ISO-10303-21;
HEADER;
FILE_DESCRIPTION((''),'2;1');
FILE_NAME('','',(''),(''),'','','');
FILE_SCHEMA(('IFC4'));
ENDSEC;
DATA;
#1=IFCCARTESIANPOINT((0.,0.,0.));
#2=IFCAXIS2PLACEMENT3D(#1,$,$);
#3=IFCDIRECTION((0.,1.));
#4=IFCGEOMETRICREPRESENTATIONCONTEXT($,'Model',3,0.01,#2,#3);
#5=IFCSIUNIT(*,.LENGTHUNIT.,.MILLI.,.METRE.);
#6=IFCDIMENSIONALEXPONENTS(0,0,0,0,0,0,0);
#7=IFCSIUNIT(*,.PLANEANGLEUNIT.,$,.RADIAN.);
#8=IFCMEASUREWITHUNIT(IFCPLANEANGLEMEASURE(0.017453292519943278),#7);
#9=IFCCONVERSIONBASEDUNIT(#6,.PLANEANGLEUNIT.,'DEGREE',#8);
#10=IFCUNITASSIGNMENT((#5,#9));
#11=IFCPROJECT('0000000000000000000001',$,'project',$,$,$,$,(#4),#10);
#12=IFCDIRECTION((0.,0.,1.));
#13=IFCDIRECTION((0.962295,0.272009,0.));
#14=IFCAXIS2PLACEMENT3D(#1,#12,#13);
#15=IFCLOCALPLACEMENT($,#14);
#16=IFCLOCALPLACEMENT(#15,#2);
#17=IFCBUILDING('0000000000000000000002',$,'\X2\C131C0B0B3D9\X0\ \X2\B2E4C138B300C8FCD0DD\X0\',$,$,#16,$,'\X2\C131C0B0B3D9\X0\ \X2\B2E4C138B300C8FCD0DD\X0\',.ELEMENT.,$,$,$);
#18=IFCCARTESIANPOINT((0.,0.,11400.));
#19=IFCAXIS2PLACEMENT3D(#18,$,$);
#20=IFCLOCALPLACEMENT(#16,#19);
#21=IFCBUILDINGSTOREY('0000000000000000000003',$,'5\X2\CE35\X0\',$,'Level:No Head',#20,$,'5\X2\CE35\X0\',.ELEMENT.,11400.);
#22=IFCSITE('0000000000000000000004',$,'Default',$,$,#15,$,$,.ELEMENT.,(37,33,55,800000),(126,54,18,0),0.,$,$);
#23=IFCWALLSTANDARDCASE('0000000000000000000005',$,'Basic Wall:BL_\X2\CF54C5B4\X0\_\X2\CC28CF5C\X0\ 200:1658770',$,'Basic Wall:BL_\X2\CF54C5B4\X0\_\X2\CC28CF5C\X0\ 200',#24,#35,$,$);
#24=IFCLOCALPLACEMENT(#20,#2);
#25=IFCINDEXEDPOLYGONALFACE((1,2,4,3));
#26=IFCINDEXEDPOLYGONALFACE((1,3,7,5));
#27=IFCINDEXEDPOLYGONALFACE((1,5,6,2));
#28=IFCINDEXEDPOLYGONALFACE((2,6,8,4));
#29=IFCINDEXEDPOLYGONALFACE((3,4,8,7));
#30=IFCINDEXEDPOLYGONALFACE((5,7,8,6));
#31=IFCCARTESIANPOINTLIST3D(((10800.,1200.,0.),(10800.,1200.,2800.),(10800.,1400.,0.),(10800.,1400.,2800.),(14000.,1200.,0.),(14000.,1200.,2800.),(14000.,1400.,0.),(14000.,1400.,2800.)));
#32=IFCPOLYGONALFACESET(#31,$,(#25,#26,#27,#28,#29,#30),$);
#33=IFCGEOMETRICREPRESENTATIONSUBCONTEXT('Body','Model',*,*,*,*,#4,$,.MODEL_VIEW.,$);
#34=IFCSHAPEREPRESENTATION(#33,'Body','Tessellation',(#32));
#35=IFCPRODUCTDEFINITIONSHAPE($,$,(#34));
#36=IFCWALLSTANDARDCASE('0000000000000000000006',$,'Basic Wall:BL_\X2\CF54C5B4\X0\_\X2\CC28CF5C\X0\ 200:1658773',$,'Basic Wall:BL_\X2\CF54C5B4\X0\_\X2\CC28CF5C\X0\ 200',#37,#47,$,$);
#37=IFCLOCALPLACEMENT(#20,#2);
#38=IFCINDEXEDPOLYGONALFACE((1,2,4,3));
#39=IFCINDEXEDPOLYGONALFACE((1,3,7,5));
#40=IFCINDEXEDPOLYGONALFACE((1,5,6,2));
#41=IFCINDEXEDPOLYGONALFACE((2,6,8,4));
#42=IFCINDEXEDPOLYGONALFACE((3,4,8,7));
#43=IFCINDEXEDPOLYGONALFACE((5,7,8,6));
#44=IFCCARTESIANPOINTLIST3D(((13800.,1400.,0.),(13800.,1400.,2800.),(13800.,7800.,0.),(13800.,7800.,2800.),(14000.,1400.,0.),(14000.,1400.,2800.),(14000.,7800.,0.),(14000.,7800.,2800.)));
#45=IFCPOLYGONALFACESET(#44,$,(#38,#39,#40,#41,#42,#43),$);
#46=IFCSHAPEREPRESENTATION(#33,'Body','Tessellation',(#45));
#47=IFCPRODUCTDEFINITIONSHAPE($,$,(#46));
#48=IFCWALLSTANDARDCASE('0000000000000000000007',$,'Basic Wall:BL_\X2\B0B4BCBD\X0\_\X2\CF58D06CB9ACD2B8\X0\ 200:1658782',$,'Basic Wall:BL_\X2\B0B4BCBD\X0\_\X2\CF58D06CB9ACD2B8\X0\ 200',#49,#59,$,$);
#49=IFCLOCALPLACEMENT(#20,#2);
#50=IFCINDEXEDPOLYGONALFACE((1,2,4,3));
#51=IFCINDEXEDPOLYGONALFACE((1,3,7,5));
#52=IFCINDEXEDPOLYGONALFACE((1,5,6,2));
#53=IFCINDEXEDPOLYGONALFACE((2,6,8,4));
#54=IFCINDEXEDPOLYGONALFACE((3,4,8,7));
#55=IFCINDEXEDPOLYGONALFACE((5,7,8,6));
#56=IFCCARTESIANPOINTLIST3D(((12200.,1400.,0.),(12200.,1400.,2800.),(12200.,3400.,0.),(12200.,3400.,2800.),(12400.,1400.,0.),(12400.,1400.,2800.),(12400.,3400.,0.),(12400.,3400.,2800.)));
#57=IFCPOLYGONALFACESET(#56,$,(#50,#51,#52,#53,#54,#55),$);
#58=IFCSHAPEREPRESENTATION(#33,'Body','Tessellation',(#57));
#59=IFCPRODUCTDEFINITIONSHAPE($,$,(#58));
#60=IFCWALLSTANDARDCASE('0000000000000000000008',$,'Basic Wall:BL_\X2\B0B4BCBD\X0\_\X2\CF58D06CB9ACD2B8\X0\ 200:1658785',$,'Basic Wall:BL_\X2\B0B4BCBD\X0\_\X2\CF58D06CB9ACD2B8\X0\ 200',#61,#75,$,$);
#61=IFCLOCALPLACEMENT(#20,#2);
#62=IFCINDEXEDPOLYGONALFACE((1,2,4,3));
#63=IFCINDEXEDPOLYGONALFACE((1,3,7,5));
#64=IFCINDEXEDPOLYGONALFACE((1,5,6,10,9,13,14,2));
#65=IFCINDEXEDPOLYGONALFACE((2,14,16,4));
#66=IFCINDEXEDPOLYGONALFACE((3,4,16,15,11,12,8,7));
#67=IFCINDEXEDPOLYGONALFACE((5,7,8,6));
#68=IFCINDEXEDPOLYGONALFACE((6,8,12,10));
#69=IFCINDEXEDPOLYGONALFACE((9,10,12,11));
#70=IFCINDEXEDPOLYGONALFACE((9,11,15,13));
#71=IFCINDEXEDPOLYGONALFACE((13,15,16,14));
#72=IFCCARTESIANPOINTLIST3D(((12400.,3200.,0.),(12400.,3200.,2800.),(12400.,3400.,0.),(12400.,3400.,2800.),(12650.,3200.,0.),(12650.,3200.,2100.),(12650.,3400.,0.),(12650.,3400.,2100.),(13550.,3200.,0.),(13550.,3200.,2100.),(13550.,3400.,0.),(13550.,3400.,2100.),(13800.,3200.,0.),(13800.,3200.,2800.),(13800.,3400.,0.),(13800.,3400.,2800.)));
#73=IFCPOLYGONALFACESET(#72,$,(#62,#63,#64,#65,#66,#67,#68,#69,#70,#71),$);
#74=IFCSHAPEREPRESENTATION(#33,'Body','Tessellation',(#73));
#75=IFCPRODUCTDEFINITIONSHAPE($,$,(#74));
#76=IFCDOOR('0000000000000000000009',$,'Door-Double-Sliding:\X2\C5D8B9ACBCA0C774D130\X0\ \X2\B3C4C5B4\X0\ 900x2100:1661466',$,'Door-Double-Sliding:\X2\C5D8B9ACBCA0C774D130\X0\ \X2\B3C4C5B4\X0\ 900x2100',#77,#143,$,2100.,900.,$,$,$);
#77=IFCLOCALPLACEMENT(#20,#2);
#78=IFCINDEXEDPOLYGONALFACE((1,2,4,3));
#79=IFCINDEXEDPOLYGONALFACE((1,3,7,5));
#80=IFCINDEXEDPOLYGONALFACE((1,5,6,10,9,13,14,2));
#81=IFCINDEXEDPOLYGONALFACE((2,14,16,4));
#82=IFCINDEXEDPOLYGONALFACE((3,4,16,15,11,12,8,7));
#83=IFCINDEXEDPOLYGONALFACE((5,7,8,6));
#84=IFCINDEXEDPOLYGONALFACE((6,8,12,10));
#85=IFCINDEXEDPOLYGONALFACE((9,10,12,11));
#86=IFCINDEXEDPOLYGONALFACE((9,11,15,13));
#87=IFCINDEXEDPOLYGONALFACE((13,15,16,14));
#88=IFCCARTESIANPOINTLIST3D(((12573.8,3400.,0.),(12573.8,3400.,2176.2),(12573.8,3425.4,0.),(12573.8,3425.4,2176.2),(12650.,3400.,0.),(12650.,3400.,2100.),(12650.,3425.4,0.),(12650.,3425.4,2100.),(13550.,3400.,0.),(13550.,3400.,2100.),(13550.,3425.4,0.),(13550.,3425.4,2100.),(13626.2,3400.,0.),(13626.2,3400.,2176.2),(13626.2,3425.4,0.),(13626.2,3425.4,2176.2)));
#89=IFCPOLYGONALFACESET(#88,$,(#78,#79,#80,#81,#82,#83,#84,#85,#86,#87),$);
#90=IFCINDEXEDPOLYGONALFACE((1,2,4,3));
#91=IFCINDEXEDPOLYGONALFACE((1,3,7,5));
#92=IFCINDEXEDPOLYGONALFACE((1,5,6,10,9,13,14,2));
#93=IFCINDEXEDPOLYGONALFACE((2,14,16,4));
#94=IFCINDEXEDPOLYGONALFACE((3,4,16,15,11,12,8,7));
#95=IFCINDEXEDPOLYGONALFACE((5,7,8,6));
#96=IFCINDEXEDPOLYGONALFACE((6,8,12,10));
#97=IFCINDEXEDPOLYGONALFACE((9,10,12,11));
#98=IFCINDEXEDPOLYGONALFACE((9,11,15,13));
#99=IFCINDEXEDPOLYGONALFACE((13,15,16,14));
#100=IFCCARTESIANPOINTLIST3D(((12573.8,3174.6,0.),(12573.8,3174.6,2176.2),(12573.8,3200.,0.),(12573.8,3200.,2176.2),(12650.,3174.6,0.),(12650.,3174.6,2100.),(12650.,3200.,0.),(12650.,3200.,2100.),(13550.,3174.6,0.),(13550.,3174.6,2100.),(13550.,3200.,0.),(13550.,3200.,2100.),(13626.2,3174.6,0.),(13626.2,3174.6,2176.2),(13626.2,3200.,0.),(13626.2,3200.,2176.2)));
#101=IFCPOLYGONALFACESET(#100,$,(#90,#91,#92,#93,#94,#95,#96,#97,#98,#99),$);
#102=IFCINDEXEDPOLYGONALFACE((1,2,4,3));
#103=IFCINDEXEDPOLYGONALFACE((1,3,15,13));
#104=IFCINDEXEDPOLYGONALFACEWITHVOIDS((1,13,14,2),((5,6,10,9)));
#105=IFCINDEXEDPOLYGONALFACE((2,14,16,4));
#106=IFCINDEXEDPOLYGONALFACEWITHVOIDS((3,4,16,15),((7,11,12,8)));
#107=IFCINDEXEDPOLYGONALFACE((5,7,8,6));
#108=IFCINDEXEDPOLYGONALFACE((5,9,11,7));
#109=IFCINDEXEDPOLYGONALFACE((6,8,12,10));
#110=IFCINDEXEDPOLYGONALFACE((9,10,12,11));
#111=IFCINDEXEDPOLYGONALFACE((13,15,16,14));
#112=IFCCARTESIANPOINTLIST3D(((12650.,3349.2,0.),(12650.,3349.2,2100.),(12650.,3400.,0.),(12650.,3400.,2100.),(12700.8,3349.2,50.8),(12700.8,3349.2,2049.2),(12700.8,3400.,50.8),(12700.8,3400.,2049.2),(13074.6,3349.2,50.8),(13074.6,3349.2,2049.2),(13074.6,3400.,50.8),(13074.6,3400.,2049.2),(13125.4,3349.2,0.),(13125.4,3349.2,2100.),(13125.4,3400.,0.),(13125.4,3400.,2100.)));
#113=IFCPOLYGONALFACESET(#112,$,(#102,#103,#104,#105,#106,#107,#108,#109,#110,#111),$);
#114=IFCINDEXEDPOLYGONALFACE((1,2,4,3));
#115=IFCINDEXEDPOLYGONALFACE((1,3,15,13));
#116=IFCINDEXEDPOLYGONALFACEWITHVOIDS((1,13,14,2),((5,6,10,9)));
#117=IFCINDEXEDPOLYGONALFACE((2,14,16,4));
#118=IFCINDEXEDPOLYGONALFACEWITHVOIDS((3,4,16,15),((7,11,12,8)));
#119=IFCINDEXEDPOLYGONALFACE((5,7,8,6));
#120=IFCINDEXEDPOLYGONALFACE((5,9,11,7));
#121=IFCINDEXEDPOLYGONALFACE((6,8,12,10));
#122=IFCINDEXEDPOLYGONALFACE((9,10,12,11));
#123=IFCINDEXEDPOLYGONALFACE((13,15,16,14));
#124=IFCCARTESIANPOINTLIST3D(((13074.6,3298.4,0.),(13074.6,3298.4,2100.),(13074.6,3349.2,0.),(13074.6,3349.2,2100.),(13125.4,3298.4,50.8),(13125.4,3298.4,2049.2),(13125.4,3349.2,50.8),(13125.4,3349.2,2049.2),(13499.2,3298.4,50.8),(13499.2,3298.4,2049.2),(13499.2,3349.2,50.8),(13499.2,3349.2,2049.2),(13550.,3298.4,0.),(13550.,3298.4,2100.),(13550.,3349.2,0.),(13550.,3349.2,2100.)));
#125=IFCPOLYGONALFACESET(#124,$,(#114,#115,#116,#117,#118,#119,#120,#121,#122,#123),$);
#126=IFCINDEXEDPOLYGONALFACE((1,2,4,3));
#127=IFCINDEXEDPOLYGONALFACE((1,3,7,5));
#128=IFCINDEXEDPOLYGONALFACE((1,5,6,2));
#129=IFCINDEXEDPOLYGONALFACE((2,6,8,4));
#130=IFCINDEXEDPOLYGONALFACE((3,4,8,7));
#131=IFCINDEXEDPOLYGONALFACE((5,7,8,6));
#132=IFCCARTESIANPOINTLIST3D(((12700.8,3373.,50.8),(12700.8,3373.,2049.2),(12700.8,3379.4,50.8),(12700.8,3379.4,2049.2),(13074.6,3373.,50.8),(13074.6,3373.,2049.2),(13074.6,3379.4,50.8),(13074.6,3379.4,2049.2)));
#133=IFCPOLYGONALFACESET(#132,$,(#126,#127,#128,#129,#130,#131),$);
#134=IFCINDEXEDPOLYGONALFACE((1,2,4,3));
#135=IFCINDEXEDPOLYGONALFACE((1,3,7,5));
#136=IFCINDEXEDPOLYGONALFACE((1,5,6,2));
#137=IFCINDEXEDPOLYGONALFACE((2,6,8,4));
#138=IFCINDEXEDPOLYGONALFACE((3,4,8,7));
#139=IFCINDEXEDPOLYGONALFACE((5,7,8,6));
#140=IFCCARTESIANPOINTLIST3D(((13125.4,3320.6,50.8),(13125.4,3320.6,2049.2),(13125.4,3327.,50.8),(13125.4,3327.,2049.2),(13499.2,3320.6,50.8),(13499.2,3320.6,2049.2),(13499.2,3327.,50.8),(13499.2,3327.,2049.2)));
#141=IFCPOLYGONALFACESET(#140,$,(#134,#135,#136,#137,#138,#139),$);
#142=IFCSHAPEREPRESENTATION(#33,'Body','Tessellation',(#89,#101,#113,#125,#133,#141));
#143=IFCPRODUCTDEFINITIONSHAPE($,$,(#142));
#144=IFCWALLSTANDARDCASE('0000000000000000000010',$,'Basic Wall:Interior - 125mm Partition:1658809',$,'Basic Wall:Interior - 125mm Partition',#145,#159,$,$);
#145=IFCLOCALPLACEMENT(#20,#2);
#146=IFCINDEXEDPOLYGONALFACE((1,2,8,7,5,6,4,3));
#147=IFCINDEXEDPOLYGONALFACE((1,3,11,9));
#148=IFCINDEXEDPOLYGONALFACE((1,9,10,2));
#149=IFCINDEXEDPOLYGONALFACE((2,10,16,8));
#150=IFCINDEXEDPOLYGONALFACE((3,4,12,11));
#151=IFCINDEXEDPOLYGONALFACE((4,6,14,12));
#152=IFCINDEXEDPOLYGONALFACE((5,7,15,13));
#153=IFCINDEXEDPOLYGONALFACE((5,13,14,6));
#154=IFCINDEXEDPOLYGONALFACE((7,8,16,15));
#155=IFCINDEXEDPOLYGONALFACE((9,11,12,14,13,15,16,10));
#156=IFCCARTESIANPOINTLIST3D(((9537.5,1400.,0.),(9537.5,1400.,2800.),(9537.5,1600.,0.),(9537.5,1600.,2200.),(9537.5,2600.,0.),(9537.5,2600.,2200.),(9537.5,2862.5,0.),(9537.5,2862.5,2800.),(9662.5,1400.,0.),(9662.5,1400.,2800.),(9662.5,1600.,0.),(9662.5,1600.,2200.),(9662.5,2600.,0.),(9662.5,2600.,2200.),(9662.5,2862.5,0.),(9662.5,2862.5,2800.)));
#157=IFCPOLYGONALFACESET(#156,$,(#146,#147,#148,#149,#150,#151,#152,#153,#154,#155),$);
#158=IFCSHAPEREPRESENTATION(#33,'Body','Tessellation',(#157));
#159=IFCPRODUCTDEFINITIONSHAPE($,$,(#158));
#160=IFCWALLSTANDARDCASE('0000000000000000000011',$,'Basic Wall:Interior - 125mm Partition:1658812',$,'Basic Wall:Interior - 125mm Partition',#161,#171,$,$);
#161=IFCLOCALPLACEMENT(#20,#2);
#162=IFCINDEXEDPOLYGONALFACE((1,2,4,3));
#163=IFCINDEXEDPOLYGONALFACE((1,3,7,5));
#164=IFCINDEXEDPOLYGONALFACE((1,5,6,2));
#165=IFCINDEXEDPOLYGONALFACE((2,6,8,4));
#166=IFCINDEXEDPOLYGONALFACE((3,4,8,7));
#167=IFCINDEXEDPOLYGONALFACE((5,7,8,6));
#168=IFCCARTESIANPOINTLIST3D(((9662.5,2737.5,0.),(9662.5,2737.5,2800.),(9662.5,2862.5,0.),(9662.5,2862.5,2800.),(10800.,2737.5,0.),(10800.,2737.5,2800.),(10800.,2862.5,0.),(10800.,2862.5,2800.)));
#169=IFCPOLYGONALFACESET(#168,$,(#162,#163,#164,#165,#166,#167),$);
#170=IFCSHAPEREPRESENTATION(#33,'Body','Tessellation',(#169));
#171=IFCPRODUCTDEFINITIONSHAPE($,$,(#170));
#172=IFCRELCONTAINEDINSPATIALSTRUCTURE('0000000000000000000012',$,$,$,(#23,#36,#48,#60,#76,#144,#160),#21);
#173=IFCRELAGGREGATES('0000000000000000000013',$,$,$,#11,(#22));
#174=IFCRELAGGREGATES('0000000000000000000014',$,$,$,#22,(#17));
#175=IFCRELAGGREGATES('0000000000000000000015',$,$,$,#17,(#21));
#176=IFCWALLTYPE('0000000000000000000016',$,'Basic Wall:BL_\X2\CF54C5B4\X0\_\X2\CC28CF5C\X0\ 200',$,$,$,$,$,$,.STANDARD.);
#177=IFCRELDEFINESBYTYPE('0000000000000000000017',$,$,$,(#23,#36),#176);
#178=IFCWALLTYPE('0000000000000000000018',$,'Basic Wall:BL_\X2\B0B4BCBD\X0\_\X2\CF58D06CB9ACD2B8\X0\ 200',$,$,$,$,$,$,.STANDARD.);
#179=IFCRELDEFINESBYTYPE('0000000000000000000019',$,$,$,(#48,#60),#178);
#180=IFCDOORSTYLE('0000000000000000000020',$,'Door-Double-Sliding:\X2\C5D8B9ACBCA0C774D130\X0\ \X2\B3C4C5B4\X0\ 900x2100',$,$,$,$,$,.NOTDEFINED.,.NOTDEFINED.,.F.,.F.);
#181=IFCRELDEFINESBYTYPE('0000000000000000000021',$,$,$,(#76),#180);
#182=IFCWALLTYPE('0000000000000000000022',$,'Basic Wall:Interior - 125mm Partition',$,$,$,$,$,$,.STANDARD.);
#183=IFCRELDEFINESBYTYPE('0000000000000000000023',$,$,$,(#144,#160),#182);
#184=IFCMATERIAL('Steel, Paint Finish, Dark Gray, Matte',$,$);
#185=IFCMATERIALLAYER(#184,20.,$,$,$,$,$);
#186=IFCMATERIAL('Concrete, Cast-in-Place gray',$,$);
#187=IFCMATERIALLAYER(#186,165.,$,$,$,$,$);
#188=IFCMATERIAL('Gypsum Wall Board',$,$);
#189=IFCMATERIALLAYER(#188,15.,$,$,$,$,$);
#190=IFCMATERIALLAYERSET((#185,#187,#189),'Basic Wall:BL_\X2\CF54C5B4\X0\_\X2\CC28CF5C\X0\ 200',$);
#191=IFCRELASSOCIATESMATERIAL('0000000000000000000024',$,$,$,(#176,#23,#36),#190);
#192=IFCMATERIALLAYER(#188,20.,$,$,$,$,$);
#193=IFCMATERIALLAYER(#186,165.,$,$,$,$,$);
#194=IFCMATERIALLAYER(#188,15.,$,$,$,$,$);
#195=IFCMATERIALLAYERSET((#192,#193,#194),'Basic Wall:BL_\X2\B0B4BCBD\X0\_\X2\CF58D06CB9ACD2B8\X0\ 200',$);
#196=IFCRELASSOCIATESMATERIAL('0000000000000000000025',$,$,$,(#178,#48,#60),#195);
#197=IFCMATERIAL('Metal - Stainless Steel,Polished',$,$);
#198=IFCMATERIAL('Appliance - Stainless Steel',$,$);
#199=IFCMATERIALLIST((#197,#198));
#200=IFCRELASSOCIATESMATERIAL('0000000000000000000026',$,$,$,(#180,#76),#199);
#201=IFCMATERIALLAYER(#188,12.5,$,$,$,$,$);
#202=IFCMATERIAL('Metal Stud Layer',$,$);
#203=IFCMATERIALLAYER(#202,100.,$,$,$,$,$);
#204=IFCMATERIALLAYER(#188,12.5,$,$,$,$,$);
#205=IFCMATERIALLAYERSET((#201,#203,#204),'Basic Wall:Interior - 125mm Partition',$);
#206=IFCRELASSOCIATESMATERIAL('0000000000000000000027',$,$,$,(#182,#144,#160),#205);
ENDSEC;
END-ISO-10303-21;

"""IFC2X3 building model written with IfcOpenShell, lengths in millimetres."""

from ifc_helpers import new_model, entity, si_unit, converted_unit, direction, frame, frame_2d, origin, place, context, subcontext, project, spatial, polyline, rectangle, outline, extrude, source, transform, mapped, material, material_list, layer, layer_set, layer_usage, type_object, type_shapes, element, fill, save


model = new_model("IFC2X3")

# Units and contexts
model_context = context("Model", 3, precision=0.01, world=origin(), true_north=direction((0.0, 1.0)))
body_context = subcontext(model_context, "Body", "Model", "MODEL_VIEW")
ifc_project = project(units=[si_unit("LENGTHUNIT", "METRE", prefix="MILLI"), converted_unit("PLANEANGLEUNIT", "DEGREE", entity("IfcPlaneAngleMeasure", 0.017453292519943278), si_unit("PLANEANGLEUNIT", "RADIAN"), dimensions=[0, 0, 0, 0, 0, 0, 0])], contexts=[model_context])

# Site, building, storey
site_placement = place(None, frame((0.0, 0.0, 0.0), z_axis=(0.0, 0.0, 1.0), x_axis=(0.962295, 0.272009, 0.0)))
site = spatial("IfcSite", under=ifc_project, at=site_placement, Name="Default", CompositionType="ELEMENT", RefLatitude=(37, 33, 55, 800000), RefLongitude=(126, 54, 18, 0), RefElevation=0.0)
building_placement = place(site_placement, origin())
building = spatial("IfcBuilding", under=site, at=building_placement, Name="성산동 다세대주택", LongName="성산동 다세대주택", CompositionType="ELEMENT")
storey_placement = place(building_placement, frame((0.0, 0.0, 11400.0)))
storey = spatial("IfcBuildingStorey", under=building, at=storey_placement, Name="5층", ObjectType="Level:No Head", LongName="5층", CompositionType="ELEMENT", Elevation=11400.0)

# Walls
ifc_material_1 = material(Name="Steel, Paint Finish, Dark Gray, Matte")
ifc_layer_1 = layer(ifc_material_1, 20.0)
ifc_material_2 = material(Name="Concrete, Cast-in-Place gray")
ifc_layer_2 = layer(ifc_material_2, 165.0)
ifc_material_3 = material(Name="Gypsum Wall Board")
ifc_layer_3 = layer(ifc_material_3, 15.0)
ifc_layer_set_1 = layer_set([ifc_layer_1, ifc_layer_2, ifc_layer_3], Name="Basic Wall:BL_코어_차콜 200")
ifc_layer_usage_1 = layer_usage(ifc_layer_set_1, "AXIS2", "POSITIVE", -100.0)
wall_type_1 = type_object("IfcWallType", Name="Basic Wall:BL_코어_차콜 200", PredefinedType="STANDARD", material=ifc_layer_set_1)
wall_1_placement = place(storey_placement, frame((10800.0, 1300.0, 0.0)))
element("IfcWallStandardCase", 1, at=wall_1_placement, inside=storey, type_object=wall_type_1, material=ifc_layer_usage_1, Name="Basic Wall:BL_코어_차콜 200:1658770", ObjectType="Basic Wall:BL_코어_차콜 200", context=body_context, shape_type="SweptSolid", body=[
    extrude(rectangle(XDim=3200.0, YDim=200.0, at=frame_2d((1600.0, 0.0), x_axis=(-1.0, 0.0))), origin(), (0.0, 0.0, 1.0), 2800.0),
])
ifc_layer_usage_2 = layer_usage(ifc_layer_set_1, "AXIS2", "POSITIVE", -100.0)
wall_2_placement = place(storey_placement, frame((13900.0, 1400.0, 0.0), z_axis=(0.0, 0.0, 1.0), x_axis=(0.0, 1.0, 0.0)))
element("IfcWallStandardCase", 2, at=wall_2_placement, inside=storey, type_object=wall_type_1, material=ifc_layer_usage_2, Name="Basic Wall:BL_코어_차콜 200:1658773", ObjectType="Basic Wall:BL_코어_차콜 200", context=body_context, shape_type="SweptSolid", body=[
    extrude(rectangle(XDim=6400.0, YDim=200.0, at=frame_2d((3200.0, 0.0), x_axis=(-1.0, 0.0))), origin(), (0.0, 0.0, 1.0), 2800.0),
])
ifc_layer_4 = layer(ifc_material_3, 20.0)
ifc_layer_5 = layer(ifc_material_2, 165.0)
ifc_layer_6 = layer(ifc_material_3, 15.0)
ifc_layer_set_2 = layer_set([ifc_layer_4, ifc_layer_5, ifc_layer_6], Name="Basic Wall:BL_내벽_콘크리트 200")
ifc_layer_usage_3 = layer_usage(ifc_layer_set_2, "AXIS2", "NEGATIVE", 100.0)
wall_type_2 = type_object("IfcWallType", Name="Basic Wall:BL_내벽_콘크리트 200", PredefinedType="STANDARD", material=ifc_layer_set_2)
wall_3_placement = place(storey_placement, frame((12300.0, 1400.0, 0.0), z_axis=(0.0, 0.0, 1.0), x_axis=(0.0, 1.0, 0.0)))
element("IfcWallStandardCase", 3, at=wall_3_placement, inside=storey, type_object=wall_type_2, material=ifc_layer_usage_3, Name="Basic Wall:BL_내벽_콘크리트 200:1658782", ObjectType="Basic Wall:BL_내벽_콘크리트 200", context=body_context, shape_type="SweptSolid", body=[
    extrude(rectangle(XDim=2000.0, YDim=200.0, at=frame_2d((1000.0, 0.0), x_axis=(-1.0, 0.0))), origin(), (0.0, 0.0, 1.0), 2800.0),
])

# Wall, opening, door
ifc_layer_usage_4 = layer_usage(ifc_layer_set_2, "AXIS2", "NEGATIVE", 100.0)
wall_4_placement = place(storey_placement, frame((12400.0, 3300.0, 0.0)))
wall_4 = element("IfcWallStandardCase", 4, at=wall_4_placement, inside=storey, type_object=wall_type_2, material=ifc_layer_usage_4, Name="Basic Wall:BL_내벽_콘크리트 200:1658785", ObjectType="Basic Wall:BL_내벽_콘크리트 200", context=body_context, shape_type="SweptSolid", body=[
    extrude(rectangle(XDim=1400.0, YDim=200.0, at=frame_2d((700.0, 0.0), x_axis=(1.0, 0.0))), origin(), (0.0, 0.0, 1.0), 2800.0),
])
opening_1_placement = place(wall_4_placement, frame((250.0, -100.0, 0.0)))
opening_1 = element("IfcOpeningElement", 5, at=opening_1_placement, cuts=wall_4, ObjectType="Opening", context=body_context, shape_type="SweptSolid", body=[
    extrude(rectangle(XDim=2100.0, YDim=900.0, at=frame_2d((1050.0, 450.0), x_axis=(-1.0, 0.0))), frame((0.0, 0.0, 0.0), z_axis=(0.0, 1.0, 0.0), x_axis=(0.0, 0.0, 1.0)), (0.0, 0.0, 1.0), 200.0),
])
ifc_material_4 = material(Name="Metal - Stainless Steel,Polished")
ifc_material_5 = material(Name="Appliance - Stainless Steel")
ifc_material_list_1 = material_list([ifc_material_4, ifc_material_5])
door_style = type_object("IfcDoorStyle", Name="Door-Double-Sliding:엘리베이터 도어 900x2100", ConstructionType="NOTDEFINED", OperationType="NOTDEFINED", ParameterTakesPrecedence=False, Sizeable=False, material=ifc_material_list_1)
shared_shape_1 = source(origin(), body_context, "Body", "SweptSolid", [
    extrude(outline(polyline([(-526.2, -1069.1), (-450.0, -1069.1), (-450.0, 1030.9), (450.0, 1031.0), (450.0, -1069.0), (526.2, -1069.0), (526.2, 1107.1), (-526.2, 1107.1), (-526.2, -1069.1)])), frame((450.0, 200.0, 1069.0), z_axis=(0.0, 1.0, 0.0), x_axis=(-1.0, 0.0, 0.0)), (0.0, 0.0, 1.0), 25.4),
    extrude(outline(polyline([(-1069.0, -526.2), (1107.1, -526.2), (1107.1, 526.2), (-1069.0, 526.2), (-1069.0, 450.0), (1030.9, 450.0), (1030.9, -450.0), (-1069.0, -450.0), (-1069.0, -526.2)])), frame((450.0, -25.4, 1069.0), z_axis=(0.0, 1.0, 0.0), x_axis=(0.0, 0.0, 1.0)), (0.0, 0.0, 1.0), 25.4),
    extrude(outline(polyline([(-1050.0, -237.7), (1050.0, -237.7), (1050.0, 237.7), (-1050.0, 237.7), (-1050.0, -237.7)]), holes=[polyline([(-999.2, -186.9), (-999.2, 186.9), (999.2, 186.9), (999.2, -186.9), (-999.2, -186.9)])]), frame((237.7, 149.2, 1050.0), z_axis=(0.0, 1.0, 0.0), x_axis=(0.0, 0.0, -1.0)), (0.0, 0.0, 1.0), 50.8),
    extrude(outline(polyline([(-237.7, -1050.0), (237.7, -1050.0), (237.7, 1050.0), (-237.7, 1050.0), (-237.7, -1050.0)]), holes=[polyline([(-186.9, -999.2), (-186.9, 999.2), (186.9, 999.2), (186.9, -999.2), (-186.9, -999.2)])]), frame((662.3, 98.4, 1050.0), z_axis=(0.0, 1.0, 0.0), x_axis=(1.0, 0.0, 0.0)), (0.0, 0.0, 1.0), 50.8),
    extrude(rectangle(XDim=6.4, YDim=373.8, at=frame_2d((0.0, 0.0), x_axis=(1.0, 0.0))), frame((237.7, 176.2, 50.8), z_axis=(0.0, 0.0, 1.0), x_axis=(0.0, 1.0, 0.0)), (0.0, 0.0, 1.0), 1998.4),
    extrude(rectangle(XDim=6.3, YDim=373.8, at=frame_2d((0.0, 0.0), x_axis=(1.0, 0.0))), frame((662.3, 123.8, 50.8), z_axis=(0.0, 0.0, 1.0), x_axis=(0.0, -1.0, 0.0)), (0.0, 0.0, 1.0), 1998.4),
])
type_shapes(door_style, [shared_shape_1])
door_placement = place(opening_1_placement, origin())
door = element("IfcDoor", 6, at=door_placement, inside=storey, type_object=door_style, material=ifc_material_list_1, Name="Door-Double-Sliding:엘리베이터 도어 900x2100:1661466", ObjectType="Door-Double-Sliding:엘리베이터 도어 900x2100", OverallHeight=2100.0, OverallWidth=900.0, context=body_context, shape_type="MappedRepresentation", body=[
    mapped(shared_shape_1, transform((0.0, 0.0, 0.0), scale=1.0)),
])
fill(opening_1, door)

# Wall, opening
ifc_layer_7 = layer(ifc_material_3, 12.5)
ifc_material_6 = material(Name="Metal Stud Layer")
ifc_layer_8 = layer(ifc_material_6, 100.0)
ifc_layer_9 = layer(ifc_material_3, 12.5)
ifc_layer_set_3 = layer_set([ifc_layer_7, ifc_layer_8, ifc_layer_9], Name="Basic Wall:Interior - 125mm Partition")
ifc_layer_usage_5 = layer_usage(ifc_layer_set_3, "AXIS2", "NEGATIVE", 62.5)
wall_type_3 = type_object("IfcWallType", Name="Basic Wall:Interior - 125mm Partition", PredefinedType="STANDARD", material=ifc_layer_set_3)
wall_5_placement = place(storey_placement, frame((9600.0, 1400.0, 0.0), z_axis=(0.0, 0.0, 1.0), x_axis=(0.0, 1.0, 0.0)))
wall_5 = element("IfcWallStandardCase", 7, at=wall_5_placement, inside=storey, type_object=wall_type_3, material=ifc_layer_usage_5, Name="Basic Wall:Interior - 125mm Partition:1658809", ObjectType="Basic Wall:Interior - 125mm Partition", context=body_context, shape_type="SweptSolid", body=[
    extrude(rectangle(XDim=1462.5, YDim=125.0, at=frame_2d((731.2, 0.0), x_axis=(-1.0, 0.0))), origin(), (0.0, 0.0, 1.0), 2800.0),
])
opening_2_placement = place(wall_5_placement, frame((200.0, -62.5, 0.0)))
element("IfcOpeningElement", 8, at=opening_2_placement, cuts=wall_5, ObjectType="Opening", context=body_context, shape_type="SweptSolid", body=[
    extrude(rectangle(XDim=2200.0, YDim=1000.0, at=frame_2d((1100.0, 500.0), x_axis=(1.0, 0.0))), frame((0.0, 0.0, 0.0), z_axis=(0.0, 1.0, 0.0), x_axis=(0.0, 0.0, 1.0)), (0.0, 0.0, 1.0), 125.0),
])

# Wall
ifc_layer_usage_6 = layer_usage(ifc_layer_set_3, "AXIS2", "NEGATIVE", 62.5)
wall_6_placement = place(storey_placement, frame((9662.5, 2800.0, 0.0)))
element("IfcWallStandardCase", 9, at=wall_6_placement, inside=storey, type_object=wall_type_3, material=ifc_layer_usage_6, Name="Basic Wall:Interior - 125mm Partition:1658812", ObjectType="Basic Wall:Interior - 125mm Partition", context=body_context, shape_type="SweptSolid", body=[
    extrude(rectangle(XDim=1137.5, YDim=125.0, at=frame_2d((568.7, 0.0), x_axis=(-1.0, 0.0))), origin(), (0.0, 0.0, 1.0), 2800.0),
])

save(model, "model.ifc")
